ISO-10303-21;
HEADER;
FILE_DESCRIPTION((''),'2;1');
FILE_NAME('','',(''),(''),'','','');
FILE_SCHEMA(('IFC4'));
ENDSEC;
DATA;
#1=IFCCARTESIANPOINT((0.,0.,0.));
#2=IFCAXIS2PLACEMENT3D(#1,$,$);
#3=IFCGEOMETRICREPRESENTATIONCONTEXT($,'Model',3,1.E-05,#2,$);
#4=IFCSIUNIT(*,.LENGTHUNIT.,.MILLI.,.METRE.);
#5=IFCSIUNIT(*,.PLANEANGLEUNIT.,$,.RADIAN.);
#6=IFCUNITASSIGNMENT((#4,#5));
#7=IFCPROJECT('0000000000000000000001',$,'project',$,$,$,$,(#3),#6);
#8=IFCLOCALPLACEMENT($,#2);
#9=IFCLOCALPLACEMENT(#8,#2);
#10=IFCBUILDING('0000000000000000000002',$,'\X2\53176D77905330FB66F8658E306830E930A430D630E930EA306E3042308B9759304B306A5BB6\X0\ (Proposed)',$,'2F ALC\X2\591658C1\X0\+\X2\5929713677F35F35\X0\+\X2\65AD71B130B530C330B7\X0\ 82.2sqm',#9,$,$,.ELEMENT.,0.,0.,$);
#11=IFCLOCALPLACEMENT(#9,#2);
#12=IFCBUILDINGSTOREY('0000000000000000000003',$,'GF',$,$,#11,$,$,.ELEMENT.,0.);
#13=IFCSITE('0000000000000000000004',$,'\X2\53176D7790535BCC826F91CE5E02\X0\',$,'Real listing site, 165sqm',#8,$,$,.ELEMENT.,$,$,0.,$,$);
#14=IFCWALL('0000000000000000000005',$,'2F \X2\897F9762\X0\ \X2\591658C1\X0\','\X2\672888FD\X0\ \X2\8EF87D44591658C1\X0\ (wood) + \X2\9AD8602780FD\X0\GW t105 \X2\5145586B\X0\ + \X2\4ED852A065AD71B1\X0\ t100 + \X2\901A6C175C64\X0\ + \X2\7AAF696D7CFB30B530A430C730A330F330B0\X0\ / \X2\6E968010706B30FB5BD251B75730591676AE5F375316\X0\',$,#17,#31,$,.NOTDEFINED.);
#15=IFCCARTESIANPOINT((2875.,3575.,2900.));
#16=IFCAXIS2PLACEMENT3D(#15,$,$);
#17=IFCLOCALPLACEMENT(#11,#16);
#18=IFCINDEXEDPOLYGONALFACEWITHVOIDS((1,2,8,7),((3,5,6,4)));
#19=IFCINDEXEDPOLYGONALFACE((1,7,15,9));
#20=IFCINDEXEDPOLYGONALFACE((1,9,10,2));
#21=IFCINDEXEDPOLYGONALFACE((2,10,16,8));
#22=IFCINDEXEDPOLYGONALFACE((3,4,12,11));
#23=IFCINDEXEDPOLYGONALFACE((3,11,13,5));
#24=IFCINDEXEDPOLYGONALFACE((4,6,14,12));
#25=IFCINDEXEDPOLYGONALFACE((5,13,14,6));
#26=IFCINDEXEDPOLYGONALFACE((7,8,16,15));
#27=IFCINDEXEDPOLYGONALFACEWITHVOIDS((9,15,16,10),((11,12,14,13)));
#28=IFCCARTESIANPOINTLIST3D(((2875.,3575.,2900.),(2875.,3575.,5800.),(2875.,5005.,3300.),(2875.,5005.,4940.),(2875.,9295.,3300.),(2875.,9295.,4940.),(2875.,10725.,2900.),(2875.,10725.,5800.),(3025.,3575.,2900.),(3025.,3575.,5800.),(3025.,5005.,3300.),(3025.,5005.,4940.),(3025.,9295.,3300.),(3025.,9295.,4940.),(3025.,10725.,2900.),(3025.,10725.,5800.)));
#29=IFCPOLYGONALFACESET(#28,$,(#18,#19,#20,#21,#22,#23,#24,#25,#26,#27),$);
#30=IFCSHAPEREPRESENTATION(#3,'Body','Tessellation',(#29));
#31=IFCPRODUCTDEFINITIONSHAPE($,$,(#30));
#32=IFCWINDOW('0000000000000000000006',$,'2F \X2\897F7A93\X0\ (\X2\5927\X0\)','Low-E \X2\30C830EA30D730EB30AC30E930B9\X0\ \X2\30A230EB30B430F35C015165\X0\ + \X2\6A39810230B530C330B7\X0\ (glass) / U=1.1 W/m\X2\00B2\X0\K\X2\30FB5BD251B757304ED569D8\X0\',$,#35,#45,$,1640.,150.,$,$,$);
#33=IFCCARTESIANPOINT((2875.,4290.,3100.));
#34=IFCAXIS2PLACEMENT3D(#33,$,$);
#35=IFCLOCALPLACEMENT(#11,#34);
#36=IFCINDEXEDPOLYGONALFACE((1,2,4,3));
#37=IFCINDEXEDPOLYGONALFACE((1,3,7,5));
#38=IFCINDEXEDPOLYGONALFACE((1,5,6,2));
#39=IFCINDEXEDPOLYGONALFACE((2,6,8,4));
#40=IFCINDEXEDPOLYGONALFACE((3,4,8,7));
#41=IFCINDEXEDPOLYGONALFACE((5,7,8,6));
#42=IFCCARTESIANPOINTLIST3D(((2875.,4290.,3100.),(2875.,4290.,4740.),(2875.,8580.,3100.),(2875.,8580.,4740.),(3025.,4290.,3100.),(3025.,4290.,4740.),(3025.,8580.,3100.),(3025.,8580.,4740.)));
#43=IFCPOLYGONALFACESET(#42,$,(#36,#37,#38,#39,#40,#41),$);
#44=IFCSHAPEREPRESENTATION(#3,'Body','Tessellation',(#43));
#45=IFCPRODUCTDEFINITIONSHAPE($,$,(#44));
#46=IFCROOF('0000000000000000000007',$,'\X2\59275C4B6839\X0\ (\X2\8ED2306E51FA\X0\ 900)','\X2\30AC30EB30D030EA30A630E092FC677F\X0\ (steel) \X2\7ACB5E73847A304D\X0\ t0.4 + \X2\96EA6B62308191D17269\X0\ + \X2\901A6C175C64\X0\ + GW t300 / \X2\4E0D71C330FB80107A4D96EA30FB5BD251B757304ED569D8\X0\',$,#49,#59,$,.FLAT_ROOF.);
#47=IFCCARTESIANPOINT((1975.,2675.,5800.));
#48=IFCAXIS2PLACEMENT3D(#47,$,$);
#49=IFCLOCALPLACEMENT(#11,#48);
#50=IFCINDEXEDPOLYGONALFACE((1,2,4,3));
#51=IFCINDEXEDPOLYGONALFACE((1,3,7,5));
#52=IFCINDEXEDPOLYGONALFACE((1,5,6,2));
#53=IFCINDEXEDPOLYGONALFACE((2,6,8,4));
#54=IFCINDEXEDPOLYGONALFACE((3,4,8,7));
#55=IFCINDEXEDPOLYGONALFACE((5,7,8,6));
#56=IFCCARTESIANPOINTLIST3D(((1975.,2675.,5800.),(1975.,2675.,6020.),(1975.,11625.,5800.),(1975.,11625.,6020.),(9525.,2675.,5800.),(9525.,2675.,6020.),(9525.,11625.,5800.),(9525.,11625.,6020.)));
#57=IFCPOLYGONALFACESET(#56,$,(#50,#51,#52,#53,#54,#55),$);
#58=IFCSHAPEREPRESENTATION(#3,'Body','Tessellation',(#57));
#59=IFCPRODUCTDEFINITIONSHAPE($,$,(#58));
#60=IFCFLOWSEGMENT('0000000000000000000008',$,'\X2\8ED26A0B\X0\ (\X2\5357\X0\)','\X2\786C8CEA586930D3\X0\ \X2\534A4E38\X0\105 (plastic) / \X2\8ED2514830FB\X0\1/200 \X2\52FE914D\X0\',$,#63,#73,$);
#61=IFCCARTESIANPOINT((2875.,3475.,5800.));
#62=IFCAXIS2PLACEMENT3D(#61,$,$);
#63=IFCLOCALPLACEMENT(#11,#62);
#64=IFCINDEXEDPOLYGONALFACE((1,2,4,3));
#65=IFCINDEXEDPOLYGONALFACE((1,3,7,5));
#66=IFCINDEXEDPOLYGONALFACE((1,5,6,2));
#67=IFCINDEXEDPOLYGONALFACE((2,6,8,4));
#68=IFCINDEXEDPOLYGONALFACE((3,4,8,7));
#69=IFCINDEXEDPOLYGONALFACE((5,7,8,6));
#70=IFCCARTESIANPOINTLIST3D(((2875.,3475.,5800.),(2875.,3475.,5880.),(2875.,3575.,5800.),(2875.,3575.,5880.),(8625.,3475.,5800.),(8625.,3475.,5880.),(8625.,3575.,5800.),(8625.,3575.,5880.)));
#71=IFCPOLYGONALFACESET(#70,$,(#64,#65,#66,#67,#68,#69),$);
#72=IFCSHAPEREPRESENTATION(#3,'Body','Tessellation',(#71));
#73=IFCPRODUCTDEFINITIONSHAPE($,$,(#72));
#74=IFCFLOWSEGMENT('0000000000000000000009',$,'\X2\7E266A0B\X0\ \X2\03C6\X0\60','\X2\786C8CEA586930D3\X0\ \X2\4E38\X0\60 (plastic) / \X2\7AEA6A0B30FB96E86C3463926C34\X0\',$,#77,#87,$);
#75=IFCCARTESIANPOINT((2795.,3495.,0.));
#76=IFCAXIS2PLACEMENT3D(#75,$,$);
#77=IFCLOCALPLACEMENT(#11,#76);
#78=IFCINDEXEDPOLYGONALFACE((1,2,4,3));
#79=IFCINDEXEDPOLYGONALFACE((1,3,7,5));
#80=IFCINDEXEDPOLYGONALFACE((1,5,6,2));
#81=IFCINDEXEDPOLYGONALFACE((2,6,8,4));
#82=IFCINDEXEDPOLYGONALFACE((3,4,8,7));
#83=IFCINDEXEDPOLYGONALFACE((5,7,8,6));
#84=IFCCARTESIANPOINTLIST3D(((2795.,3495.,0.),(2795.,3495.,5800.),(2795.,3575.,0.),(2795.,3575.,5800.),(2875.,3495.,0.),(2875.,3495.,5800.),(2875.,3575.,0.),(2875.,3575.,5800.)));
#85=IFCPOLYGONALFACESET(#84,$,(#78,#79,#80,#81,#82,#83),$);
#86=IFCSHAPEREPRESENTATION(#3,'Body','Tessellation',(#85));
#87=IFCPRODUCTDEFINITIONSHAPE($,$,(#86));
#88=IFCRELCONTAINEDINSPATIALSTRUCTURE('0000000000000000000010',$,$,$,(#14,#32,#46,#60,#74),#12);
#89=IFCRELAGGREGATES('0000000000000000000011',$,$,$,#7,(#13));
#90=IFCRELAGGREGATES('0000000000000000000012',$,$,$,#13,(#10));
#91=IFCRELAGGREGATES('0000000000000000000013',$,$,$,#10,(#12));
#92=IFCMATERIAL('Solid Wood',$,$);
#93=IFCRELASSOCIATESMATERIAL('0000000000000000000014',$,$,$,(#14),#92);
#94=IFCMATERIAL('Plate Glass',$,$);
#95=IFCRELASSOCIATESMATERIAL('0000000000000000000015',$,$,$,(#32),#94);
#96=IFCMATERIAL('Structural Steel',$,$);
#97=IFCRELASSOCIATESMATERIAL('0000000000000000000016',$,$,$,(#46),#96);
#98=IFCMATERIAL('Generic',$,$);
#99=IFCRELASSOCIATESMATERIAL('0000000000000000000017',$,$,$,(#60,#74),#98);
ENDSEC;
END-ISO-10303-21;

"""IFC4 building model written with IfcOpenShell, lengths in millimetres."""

from ifc_helpers import new_model, si_unit, frame, frame_2d, origin, place, context, project, spatial, rectangle, extrude, material, element, fill, save


model = new_model("IFC4")

# Units and contexts
model_context = context("Model", 3, precision=1e-05, world=origin())
ifc_project = project(units=[si_unit("LENGTHUNIT", "METRE", prefix="MILLI"), si_unit("PLANEANGLEUNIT", "RADIAN")], contexts=[model_context])

# Site, building, storey
site_placement = place(None, origin())
site = spatial("IfcSite", under=ifc_project, at=site_placement, Name="北海道富良野市", ObjectType="Real listing site, 165sqm", CompositionType="ELEMENT", RefElevation=0.0)
building_placement = place(site_placement, origin())
building = spatial("IfcBuilding", under=site, at=building_placement, Name="北海道・書斎とライブラリのある静かな家 (Proposed)", ObjectType="2F ALC外壁+天然石張+断熱サッシ 82.2sqm", CompositionType="ELEMENT", ElevationOfRefHeight=0.0, ElevationOfTerrain=0.0)
storey_placement = place(building_placement, origin())
storey = spatial("IfcBuildingStorey", under=building, at=storey_placement, Name="GF", CompositionType="ELEMENT", Elevation=0.0)

# Shared definitions
ifc_material_1 = material(Name="Solid Wood")

# Shared definitions
ifc_material_2 = material(Name="Plate Glass")

# Wall, opening, window
wall_1_placement = place(storey_placement, frame((2875.0, 3575.0, 2900.0)))
wall_1 = element("IfcWall", 1, at=wall_1_placement, inside=storey, material=ifc_material_1, Name="2F 西面 外壁", Description="木製 軸組外壁 (wood) + 高性能GW t105 充填 + 付加断熱 t100 + 通気層 + 窯業系サイディング / 準耐火・寒冷地外皮強化", PredefinedType="NOTDEFINED", context=model_context, shape_type="SweptSolid", body=[
    extrude(rectangle(XDim=150.0, YDim=7150.0, at=frame_2d((75.0, 3575.0))), frame((2875.0, 3575.0, 2900.0)), (0.0, 0.0, 1.0), 2900.0),
])
opening_1_placement = place(storey_placement, frame((2875.0, 4290.0, 3100.0)))
opening_1 = element("IfcOpeningElement", 2, at=opening_1_placement, cuts=wall_1, PredefinedType="NOTDEFINED", context=model_context, shape_type="SweptSolid", body=[
    extrude(rectangle(XDim=150.0, YDim=4290.0, at=frame_2d((75.0, 2145.0))), frame((2875.0, 4290.0, 3100.0)), (0.0, 0.0, 1.0), 1640.0),
])
window_1_placement = place(storey_placement, frame((2875.0, 4290.0, 3100.0)))
window_1 = element("IfcWindow", 3, at=window_1_placement, inside=storey, material=ifc_material_2, Name="2F 西窓 (大)", Description="Low-E トリプルガラス アルゴン封入 + 樹脂サッシ (glass) / U=1.1 W/m²K・寒冷地仕様", OverallHeight=1640.0, OverallWidth=150.0, context=model_context, shape_type="SweptSolid", body=[
    extrude(rectangle(XDim=150.0, YDim=4290.0, at=frame_2d((75.0, 2145.0))), frame((2875.0, 4290.0, 3100.0)), (0.0, 0.0, 1.0), 1640.0),
])
fill(opening_1, window_1)

# Roof
ifc_material_3 = material(Name="Structural Steel")
roof_placement = place(storey_placement, frame((1975.0, 2675.0, 5800.0)))
element("IfcRoof", 4, at=roof_placement, inside=storey, material=ifc_material_3, Name="大屋根 (軒の出 900)", Description="ガルバリウム鋼板 (steel) 立平葺き t0.4 + 雪止め金物 + 通気層 + GW t300 / 不燃・耐積雪・寒冷地仕様", PredefinedType="FLAT_ROOF", context=model_context, shape_type="SweptSolid", body=[
    extrude(rectangle(XDim=7550.0, YDim=8950.0, at=frame_2d((3775.0, 4475.0))), frame((1975.0, 2675.0, 5800.0)), (0.0, 0.0, 1.0), 220.0),
])

# Flow segments
ifc_material_4 = material(Name="Generic")
flow_segment_1_placement = place(storey_placement, frame((2875.0, 3475.0, 5800.0)))
element("IfcFlowSegment", 5, at=flow_segment_1_placement, inside=storey, material=ifc_material_4, Name="軒樋 (南)", Description="硬質塩ビ 半丸105 (plastic) / 軒先・1/200 勾配", context=model_context, shape_type="SweptSolid", body=[
    extrude(rectangle(XDim=5750.0, YDim=100.0, at=frame_2d((2875.0, 50.0))), frame((2875.0, 3475.0, 5800.0)), (0.0, 0.0, 1.0), 80.0),
])
flow_segment_2_placement = place(storey_placement, frame((2795.0, 3495.0, 0.0)))
element("IfcFlowSegment", 6, at=flow_segment_2_placement, inside=storey, material=ifc_material_4, Name="縦樋 φ60", Description="硬質塩ビ 丸60 (plastic) / 竪樋・雨水排水", context=model_context, shape_type="SweptSolid", body=[
    extrude(rectangle(XDim=80.0, YDim=80.0, at=frame_2d((40.0, 40.0))), frame((2795.0, 3495.0, 0.0)), (0.0, 0.0, 1.0), 5800.0),
])

save(model, "model.ifc")
